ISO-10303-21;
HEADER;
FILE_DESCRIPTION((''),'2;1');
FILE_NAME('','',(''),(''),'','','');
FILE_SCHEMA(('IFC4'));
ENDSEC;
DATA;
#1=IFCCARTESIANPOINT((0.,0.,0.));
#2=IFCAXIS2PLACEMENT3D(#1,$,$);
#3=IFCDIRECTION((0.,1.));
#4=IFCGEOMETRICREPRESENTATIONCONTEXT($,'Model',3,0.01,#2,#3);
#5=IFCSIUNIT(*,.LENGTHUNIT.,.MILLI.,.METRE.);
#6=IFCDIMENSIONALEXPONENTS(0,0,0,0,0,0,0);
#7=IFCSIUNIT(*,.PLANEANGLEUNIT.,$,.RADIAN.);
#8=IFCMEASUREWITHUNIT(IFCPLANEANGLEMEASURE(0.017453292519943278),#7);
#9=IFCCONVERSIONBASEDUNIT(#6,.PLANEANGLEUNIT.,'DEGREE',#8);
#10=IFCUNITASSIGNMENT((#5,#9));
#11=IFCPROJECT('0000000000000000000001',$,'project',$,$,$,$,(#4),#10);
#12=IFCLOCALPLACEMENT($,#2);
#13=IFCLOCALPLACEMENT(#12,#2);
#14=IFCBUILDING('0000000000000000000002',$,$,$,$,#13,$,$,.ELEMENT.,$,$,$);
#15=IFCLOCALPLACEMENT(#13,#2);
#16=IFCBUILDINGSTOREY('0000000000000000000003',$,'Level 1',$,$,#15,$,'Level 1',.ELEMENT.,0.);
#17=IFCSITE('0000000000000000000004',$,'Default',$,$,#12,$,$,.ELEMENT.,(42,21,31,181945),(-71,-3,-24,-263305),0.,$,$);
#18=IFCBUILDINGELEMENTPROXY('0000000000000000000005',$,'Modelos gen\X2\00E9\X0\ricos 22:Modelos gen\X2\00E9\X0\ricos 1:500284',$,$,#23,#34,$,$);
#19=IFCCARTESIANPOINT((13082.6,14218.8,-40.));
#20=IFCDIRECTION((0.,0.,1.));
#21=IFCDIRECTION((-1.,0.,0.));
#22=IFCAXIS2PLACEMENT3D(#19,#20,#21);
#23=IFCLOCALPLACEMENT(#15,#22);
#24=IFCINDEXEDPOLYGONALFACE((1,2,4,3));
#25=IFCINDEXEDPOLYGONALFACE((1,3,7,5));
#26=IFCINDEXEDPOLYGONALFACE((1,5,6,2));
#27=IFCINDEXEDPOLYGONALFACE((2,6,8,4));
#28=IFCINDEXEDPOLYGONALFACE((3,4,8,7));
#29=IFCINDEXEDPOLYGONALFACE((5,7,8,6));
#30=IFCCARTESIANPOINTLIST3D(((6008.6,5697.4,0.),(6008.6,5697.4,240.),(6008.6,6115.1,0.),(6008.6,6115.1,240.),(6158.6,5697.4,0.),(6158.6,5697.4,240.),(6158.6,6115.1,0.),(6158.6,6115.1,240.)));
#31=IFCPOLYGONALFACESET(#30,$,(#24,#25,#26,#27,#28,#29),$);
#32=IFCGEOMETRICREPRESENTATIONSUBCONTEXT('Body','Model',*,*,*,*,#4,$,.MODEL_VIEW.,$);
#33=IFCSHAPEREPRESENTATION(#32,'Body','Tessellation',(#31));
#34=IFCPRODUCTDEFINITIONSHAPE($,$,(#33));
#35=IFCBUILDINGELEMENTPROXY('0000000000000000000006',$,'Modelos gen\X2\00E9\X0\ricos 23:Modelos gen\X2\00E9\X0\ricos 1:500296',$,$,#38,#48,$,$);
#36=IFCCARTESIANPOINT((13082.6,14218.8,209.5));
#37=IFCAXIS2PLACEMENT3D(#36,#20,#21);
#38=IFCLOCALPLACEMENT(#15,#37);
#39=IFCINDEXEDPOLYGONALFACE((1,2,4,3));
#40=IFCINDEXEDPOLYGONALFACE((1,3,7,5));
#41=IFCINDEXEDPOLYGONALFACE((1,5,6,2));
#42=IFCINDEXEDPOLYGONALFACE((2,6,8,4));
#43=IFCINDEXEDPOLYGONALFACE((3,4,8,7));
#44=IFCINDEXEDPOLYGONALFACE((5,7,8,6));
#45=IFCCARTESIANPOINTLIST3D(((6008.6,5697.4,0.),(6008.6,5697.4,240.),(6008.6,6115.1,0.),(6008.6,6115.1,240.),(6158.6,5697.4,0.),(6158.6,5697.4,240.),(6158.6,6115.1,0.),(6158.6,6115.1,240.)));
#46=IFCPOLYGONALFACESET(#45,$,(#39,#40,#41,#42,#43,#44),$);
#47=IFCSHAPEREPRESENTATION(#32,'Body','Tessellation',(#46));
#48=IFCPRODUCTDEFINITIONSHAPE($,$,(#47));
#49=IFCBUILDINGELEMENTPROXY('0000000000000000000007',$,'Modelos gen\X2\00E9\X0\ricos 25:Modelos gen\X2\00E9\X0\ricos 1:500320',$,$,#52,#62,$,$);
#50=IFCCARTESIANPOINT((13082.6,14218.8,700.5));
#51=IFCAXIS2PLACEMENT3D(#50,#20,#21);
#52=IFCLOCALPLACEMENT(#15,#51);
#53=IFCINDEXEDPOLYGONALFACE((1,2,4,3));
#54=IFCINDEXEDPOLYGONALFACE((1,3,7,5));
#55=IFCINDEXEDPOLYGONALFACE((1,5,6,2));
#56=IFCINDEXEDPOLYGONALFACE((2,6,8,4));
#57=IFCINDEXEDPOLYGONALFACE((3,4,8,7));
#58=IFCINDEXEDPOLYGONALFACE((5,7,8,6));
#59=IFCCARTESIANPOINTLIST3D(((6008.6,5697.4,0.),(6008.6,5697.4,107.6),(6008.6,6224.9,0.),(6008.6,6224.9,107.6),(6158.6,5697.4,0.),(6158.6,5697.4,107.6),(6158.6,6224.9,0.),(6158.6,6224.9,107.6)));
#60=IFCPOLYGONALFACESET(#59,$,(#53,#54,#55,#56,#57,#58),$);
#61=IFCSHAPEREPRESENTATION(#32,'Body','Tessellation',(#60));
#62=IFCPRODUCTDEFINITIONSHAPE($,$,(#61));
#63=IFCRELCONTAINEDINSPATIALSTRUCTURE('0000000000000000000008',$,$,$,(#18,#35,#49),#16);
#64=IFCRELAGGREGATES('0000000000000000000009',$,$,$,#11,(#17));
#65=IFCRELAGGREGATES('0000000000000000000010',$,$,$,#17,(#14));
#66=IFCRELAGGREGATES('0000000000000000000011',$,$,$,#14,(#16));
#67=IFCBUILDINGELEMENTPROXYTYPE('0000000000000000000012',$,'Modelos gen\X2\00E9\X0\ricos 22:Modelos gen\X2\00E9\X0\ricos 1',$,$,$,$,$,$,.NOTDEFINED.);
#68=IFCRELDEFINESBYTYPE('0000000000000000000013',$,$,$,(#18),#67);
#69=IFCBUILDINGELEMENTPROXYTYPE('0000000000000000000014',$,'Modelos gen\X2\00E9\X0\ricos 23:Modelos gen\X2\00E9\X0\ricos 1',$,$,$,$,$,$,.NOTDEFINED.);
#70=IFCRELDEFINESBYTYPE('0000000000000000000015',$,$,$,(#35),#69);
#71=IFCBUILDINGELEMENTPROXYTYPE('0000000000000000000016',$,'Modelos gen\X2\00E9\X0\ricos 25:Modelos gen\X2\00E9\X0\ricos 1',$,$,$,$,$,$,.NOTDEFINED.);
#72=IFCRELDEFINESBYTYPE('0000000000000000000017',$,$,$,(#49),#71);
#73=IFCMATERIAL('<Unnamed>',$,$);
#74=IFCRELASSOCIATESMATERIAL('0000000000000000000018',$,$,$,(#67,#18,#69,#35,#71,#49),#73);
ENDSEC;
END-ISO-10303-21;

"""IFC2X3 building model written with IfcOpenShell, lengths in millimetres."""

from ifc_helpers import new_model, entity, si_unit, converted_unit, direction, frame, frame_2d, origin, place, context, subcontext, project, spatial, rectangle, extrude, source, transform, mapped, material, type_object, type_shapes, element, save


model = new_model("IFC2X3")

# Units and contexts
model_context = context("Model", 3, precision=0.01, world=origin(), true_north=direction((0.0, 1.0)))
body_context = subcontext(model_context, "Body", "Model", "MODEL_VIEW")
ifc_project = project(units=[si_unit("LENGTHUNIT", "METRE", prefix="MILLI"), converted_unit("PLANEANGLEUNIT", "DEGREE", entity("IfcPlaneAngleMeasure", 0.017453292519943278), si_unit("PLANEANGLEUNIT", "RADIAN"), dimensions=[0, 0, 0, 0, 0, 0, 0])], contexts=[model_context])

# Site, building, storey
site_placement = place(None, origin())
site = spatial("IfcSite", under=ifc_project, at=site_placement, Name="Default", CompositionType="ELEMENT", RefLatitude=(42, 21, 31, 181945), RefLongitude=(-71, -3, -24, -263305), RefElevation=0.0)
building_placement = place(site_placement, origin())
building = spatial("IfcBuilding", under=site, at=building_placement, CompositionType="ELEMENT")
storey_placement = place(building_placement, origin())
storey = spatial("IfcBuildingStorey", under=building, at=storey_placement, Name="Level 1", LongName="Level 1", CompositionType="ELEMENT", Elevation=0.0)

# Building element proxies
ifc_material_1 = material(Name="<Unnamed>")
building_element_proxy_type_1 = type_object("IfcBuildingElementProxyType", Name="Modelos genéricos 22:Modelos genéricos 1", PredefinedType="NOTDEFINED", material=ifc_material_1)
shared_shape_1 = source(origin(), body_context, "Body", "SweptSolid", [
    extrude(rectangle(XDim=150.0, YDim=417.7, at=frame_2d((0.0, 0.0), x_axis=(1.0, 0.0))), frame((6083.6, 5906.2, 0.0), z_axis=(0.0, 0.0, 1.0), x_axis=(-1.0, 0.0, 0.0)), (0.0, 0.0, 1.0), 240.0),
])
type_shapes(building_element_proxy_type_1, [shared_shape_1])
proxy_1_placement = place(storey_placement, frame((13082.6, 14218.8, -40.0), z_axis=(0.0, 0.0, 1.0), x_axis=(-1.0, 0.0, 0.0)))
element("IfcBuildingElementProxy", 1, at=proxy_1_placement, inside=storey, type_object=building_element_proxy_type_1, material=ifc_material_1, Name="Modelos genéricos 22:Modelos genéricos 1:500284", context=body_context, shape_type="MappedRepresentation", body=[
    mapped(shared_shape_1, transform((0.0, 0.0, 0.0), scale=1.0)),
])
building_element_proxy_type_2 = type_object("IfcBuildingElementProxyType", Name="Modelos genéricos 23:Modelos genéricos 1", PredefinedType="NOTDEFINED", material=ifc_material_1)
shared_shape_2 = source(origin(), body_context, "Body", "SweptSolid", [
    extrude(rectangle(XDim=150.0, YDim=417.7, at=frame_2d((0.0, 0.0), x_axis=(1.0, 0.0))), frame((6083.6, 5906.2, 0.0), z_axis=(0.0, 0.0, 1.0), x_axis=(-1.0, 0.0, 0.0)), (0.0, 0.0, 1.0), 240.0),
])
type_shapes(building_element_proxy_type_2, [shared_shape_2])
proxy_2_placement = place(storey_placement, frame((13082.6, 14218.8, 209.5), z_axis=(0.0, 0.0, 1.0), x_axis=(-1.0, 0.0, 0.0)))
element("IfcBuildingElementProxy", 2, at=proxy_2_placement, inside=storey, type_object=building_element_proxy_type_2, material=ifc_material_1, Name="Modelos genéricos 23:Modelos genéricos 1:500296", context=body_context, shape_type="MappedRepresentation", body=[
    mapped(shared_shape_2, transform((0.0, 0.0, 0.0), scale=1.0)),
])
building_element_proxy_type_3 = type_object("IfcBuildingElementProxyType", Name="Modelos genéricos 25:Modelos genéricos 1", PredefinedType="NOTDEFINED", material=ifc_material_1)
shared_shape_3 = source(origin(), body_context, "Body", "SweptSolid", [
    extrude(rectangle(XDim=150.0, YDim=527.5, at=frame_2d((0.0, 0.0), x_axis=(1.0, 0.0))), frame((6083.6, 5961.1, 0.0), z_axis=(0.0, 0.0, 1.0), x_axis=(-1.0, 0.0, 0.0)), (0.0, 0.0, 1.0), 107.6),
])
type_shapes(building_element_proxy_type_3, [shared_shape_3])
proxy_3_placement = place(storey_placement, frame((13082.6, 14218.8, 700.5), z_axis=(0.0, 0.0, 1.0), x_axis=(-1.0, 0.0, 0.0)))
element("IfcBuildingElementProxy", 3, at=proxy_3_placement, inside=storey, type_object=building_element_proxy_type_3, material=ifc_material_1, Name="Modelos genéricos 25:Modelos genéricos 1:500320", context=body_context, shape_type="MappedRepresentation", body=[
    mapped(shared_shape_3, transform((0.0, 0.0, 0.0), scale=1.0)),
])

save(model, "model.ifc")
